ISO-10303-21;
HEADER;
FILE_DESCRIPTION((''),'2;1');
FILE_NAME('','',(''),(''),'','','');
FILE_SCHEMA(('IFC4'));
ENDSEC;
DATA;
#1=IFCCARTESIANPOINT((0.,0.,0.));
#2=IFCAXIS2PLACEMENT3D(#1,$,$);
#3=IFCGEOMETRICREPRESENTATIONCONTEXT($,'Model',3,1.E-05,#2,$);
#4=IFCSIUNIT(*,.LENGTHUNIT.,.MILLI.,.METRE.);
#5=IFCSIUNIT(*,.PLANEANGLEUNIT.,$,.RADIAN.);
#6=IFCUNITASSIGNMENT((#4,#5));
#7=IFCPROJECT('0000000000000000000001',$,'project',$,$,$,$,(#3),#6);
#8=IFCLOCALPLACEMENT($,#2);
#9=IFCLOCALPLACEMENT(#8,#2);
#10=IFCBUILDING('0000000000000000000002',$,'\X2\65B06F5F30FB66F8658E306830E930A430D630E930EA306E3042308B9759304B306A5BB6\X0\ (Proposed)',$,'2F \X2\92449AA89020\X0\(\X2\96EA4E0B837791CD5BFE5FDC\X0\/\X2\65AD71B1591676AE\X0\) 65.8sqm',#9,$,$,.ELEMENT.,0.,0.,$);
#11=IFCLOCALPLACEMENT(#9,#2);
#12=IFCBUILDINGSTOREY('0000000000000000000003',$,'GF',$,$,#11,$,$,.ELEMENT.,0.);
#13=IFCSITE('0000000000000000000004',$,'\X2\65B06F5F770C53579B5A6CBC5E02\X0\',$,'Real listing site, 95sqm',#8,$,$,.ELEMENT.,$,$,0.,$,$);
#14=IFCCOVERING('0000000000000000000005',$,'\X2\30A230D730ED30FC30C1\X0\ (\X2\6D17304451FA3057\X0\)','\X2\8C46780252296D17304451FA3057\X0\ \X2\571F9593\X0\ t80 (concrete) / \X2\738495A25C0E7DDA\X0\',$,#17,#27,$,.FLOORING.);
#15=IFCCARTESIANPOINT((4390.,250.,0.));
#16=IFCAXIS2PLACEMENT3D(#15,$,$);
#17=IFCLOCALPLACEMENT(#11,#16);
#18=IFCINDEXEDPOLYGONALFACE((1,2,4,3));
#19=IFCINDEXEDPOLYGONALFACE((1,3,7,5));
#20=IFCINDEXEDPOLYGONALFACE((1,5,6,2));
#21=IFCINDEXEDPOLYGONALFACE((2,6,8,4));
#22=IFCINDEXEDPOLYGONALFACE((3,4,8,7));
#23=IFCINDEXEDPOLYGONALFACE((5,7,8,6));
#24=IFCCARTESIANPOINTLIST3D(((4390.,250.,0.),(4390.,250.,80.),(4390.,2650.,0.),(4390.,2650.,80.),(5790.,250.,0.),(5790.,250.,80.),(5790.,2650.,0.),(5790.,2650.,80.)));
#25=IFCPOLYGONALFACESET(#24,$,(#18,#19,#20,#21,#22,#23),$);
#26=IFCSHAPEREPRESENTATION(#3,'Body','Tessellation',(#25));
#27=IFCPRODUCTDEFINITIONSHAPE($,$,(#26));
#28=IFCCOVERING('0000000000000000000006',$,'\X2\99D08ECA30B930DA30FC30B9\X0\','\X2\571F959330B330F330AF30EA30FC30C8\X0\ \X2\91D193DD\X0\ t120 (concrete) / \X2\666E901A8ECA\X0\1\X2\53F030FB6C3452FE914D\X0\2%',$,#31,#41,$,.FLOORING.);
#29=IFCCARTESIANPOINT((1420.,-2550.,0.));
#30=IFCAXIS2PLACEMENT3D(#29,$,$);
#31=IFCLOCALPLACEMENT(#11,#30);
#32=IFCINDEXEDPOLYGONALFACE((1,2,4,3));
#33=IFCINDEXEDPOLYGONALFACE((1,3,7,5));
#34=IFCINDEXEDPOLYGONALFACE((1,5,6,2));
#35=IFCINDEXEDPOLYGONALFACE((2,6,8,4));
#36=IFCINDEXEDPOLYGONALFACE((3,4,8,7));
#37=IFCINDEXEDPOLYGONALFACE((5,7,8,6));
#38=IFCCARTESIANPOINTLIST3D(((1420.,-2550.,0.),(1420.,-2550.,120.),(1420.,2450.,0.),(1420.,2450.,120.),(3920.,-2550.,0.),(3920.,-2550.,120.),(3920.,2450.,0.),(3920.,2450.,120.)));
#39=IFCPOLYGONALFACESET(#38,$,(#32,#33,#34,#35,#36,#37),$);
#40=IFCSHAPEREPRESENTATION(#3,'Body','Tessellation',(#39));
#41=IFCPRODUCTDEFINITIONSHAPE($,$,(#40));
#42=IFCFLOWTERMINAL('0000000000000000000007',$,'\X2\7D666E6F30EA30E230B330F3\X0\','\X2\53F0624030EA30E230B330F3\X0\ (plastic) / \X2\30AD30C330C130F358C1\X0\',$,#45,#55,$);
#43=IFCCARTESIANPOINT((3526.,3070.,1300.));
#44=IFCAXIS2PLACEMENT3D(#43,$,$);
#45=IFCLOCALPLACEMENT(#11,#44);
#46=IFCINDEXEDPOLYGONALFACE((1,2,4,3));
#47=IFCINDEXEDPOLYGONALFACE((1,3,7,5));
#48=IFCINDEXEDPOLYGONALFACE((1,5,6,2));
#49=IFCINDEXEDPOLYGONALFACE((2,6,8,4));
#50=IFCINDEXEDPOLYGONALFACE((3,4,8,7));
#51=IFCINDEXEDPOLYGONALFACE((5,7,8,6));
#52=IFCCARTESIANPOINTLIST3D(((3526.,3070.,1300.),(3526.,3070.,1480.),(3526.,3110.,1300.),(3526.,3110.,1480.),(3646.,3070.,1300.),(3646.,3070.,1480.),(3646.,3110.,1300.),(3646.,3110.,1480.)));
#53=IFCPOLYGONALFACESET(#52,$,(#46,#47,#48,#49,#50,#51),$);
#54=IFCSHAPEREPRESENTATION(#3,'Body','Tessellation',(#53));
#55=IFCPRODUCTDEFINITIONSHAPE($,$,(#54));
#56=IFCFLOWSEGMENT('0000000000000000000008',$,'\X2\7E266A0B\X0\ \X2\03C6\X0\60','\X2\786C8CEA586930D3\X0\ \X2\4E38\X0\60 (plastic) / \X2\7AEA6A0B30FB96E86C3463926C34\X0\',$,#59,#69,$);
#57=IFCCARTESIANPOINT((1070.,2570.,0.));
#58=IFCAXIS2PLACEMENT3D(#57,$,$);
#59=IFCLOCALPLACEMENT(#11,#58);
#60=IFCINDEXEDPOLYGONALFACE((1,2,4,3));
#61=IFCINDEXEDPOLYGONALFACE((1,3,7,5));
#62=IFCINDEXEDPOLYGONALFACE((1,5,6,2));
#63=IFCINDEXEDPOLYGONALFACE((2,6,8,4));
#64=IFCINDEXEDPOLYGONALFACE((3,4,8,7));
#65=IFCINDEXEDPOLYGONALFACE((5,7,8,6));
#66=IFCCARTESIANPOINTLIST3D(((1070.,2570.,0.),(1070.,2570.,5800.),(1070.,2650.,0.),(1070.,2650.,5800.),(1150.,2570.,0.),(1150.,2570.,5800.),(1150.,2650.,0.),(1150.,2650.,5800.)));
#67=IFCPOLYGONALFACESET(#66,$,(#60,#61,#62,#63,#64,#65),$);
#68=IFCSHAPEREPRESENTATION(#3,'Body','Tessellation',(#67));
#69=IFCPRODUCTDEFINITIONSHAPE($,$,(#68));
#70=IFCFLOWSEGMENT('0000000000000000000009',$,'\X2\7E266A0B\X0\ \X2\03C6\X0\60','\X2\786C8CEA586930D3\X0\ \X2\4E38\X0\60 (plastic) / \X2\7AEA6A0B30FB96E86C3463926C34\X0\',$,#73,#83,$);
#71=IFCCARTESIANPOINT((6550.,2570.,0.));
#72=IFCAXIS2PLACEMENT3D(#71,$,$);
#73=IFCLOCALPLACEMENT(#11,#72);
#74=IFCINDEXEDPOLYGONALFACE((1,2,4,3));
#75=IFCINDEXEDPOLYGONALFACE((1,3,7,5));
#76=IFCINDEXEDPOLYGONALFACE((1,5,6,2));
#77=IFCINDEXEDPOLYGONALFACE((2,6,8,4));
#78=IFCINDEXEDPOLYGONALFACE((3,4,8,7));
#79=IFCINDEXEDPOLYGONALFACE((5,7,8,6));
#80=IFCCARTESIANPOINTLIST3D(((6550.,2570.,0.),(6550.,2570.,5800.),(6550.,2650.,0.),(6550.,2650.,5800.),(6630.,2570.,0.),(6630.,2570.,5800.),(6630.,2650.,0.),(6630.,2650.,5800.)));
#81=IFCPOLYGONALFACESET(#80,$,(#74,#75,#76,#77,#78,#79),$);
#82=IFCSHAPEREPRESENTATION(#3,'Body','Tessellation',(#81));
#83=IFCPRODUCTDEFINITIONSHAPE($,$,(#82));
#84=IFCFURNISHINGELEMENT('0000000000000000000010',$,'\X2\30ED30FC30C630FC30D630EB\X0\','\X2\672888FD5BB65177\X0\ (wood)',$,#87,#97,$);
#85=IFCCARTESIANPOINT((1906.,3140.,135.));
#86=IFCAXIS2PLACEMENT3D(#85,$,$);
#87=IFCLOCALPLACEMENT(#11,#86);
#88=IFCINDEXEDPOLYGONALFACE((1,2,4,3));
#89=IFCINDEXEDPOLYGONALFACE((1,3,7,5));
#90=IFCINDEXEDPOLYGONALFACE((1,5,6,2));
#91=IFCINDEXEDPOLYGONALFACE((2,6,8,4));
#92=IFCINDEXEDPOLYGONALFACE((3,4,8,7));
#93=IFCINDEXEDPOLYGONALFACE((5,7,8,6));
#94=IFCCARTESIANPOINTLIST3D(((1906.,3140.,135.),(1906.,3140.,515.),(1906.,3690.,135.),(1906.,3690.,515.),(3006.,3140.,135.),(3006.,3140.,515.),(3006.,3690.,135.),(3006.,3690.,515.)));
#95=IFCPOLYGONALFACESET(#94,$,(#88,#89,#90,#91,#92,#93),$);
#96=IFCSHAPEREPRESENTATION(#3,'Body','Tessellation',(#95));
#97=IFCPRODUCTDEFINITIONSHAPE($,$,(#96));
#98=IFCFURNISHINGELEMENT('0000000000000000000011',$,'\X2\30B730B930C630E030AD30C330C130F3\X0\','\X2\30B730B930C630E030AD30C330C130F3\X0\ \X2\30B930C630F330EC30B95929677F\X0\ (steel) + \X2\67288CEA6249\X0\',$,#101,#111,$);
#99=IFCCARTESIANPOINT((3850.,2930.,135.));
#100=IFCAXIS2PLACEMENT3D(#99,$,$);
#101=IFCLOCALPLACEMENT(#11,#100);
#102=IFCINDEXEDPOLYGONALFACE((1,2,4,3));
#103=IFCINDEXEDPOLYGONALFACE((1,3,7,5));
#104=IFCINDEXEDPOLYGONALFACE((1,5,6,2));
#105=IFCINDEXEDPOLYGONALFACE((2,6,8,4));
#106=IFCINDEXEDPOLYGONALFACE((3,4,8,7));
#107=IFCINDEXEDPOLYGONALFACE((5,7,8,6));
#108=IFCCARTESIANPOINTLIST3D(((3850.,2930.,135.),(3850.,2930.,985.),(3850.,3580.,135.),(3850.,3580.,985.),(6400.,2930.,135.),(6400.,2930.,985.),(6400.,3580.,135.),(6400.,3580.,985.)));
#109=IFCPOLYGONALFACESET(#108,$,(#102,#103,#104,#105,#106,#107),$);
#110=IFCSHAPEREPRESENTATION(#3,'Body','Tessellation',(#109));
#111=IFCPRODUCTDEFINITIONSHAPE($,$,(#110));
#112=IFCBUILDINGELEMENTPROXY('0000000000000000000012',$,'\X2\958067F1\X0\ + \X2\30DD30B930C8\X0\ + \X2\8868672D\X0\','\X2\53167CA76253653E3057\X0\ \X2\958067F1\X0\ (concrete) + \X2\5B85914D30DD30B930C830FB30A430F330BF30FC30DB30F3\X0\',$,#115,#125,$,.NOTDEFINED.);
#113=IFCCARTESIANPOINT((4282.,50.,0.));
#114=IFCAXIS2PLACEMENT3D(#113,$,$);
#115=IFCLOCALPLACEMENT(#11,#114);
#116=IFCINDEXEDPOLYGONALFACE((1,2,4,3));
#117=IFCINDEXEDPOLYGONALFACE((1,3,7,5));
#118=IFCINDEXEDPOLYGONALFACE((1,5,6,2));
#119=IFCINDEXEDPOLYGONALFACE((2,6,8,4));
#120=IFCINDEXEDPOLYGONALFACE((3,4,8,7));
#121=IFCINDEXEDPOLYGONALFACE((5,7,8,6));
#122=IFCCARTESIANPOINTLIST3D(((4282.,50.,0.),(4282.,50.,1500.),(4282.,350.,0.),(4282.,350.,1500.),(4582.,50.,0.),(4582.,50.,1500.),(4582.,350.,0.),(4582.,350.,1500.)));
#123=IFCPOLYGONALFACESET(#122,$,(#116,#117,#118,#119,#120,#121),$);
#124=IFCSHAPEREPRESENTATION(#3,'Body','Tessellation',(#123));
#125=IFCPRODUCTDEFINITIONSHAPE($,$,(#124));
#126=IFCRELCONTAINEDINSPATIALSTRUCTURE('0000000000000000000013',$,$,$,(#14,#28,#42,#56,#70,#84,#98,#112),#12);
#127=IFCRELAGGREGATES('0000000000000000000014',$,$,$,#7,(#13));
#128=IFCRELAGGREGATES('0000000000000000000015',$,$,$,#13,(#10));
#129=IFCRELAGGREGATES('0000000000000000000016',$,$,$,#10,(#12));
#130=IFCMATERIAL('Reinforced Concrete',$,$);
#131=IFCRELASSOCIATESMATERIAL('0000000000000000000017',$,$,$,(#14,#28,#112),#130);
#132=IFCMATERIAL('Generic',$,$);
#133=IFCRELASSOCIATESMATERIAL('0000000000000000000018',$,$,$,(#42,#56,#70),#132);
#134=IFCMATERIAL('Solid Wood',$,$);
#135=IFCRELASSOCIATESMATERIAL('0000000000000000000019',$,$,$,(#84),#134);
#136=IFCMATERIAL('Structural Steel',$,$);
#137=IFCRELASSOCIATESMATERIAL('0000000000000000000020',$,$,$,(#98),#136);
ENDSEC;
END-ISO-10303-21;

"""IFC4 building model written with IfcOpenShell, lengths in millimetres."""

from ifc_helpers import new_model, si_unit, frame, frame_2d, origin, place, context, project, spatial, rectangle, extrude, material, element, save


model = new_model("IFC4")

# Units and contexts
model_context = context("Model", 3, precision=1e-05, world=origin())
ifc_project = project(units=[si_unit("LENGTHUNIT", "METRE", prefix="MILLI"), si_unit("PLANEANGLEUNIT", "RADIAN")], contexts=[model_context])

# Site, building, storey
site_placement = place(None, origin())
site = spatial("IfcSite", under=ifc_project, at=site_placement, Name="新潟県南魚沼市", ObjectType="Real listing site, 95sqm", CompositionType="ELEMENT", RefElevation=0.0)
building_placement = place(site_placement, origin())
building = spatial("IfcBuilding", under=site, at=building_placement, Name="新潟・書斎とライブラリのある静かな家 (Proposed)", ObjectType="2F 鉄骨造(雪下荷重対応/断熱外皮) 65.8sqm", CompositionType="ELEMENT", ElevationOfRefHeight=0.0, ElevationOfTerrain=0.0)
storey_placement = place(building_placement, origin())
storey = spatial("IfcBuildingStorey", under=building, at=storey_placement, Name="GF", CompositionType="ELEMENT", Elevation=0.0)

# Shared definitions
ifc_material_1 = material(Name="Solid Wood")

# Shared definitions
ifc_material_2 = material(Name="Reinforced Concrete")

# Coverings
ifc_material_3 = material(Name="Generic")
covering_1_placement = place(storey_placement, frame((4390.0, 250.0, 0.0)))
element("IfcCovering", 1, at=covering_1_placement, inside=storey, material=ifc_material_2, Name="アプローチ (洗い出し)", Description="豆砂利洗い出し 土間 t80 (concrete) / 玄関導線", PredefinedType="FLOORING", context=model_context, shape_type="SweptSolid", body=[
    extrude(rectangle(XDim=1400.0, YDim=2400.0, at=frame_2d((700.0, 1200.0))), frame((4390.0, 250.0, 0.0)), (0.0, 0.0, 1.0), 80.0),
])
covering_2_placement = place(storey_placement, frame((1420.0, -2550.0, 0.0)))
element("IfcCovering", 2, at=covering_2_placement, inside=storey, material=ifc_material_2, Name="駐車スペース", Description="土間コンクリート 金鏝 t120 (concrete) / 普通車1台・水勾配2%", PredefinedType="FLOORING", context=model_context, shape_type="SweptSolid", body=[
    extrude(rectangle(XDim=2500.0, YDim=5000.0, at=frame_2d((1250.0, 2500.0))), frame((1420.0, -2550.0, 0.0)), (0.0, 0.0, 1.0), 120.0),
])

# Flow terminal
flow_terminal_placement = place(storey_placement, frame((3526.0, 3070.0, 1300.0)))
element("IfcFlowTerminal", 3, at=flow_terminal_placement, inside=storey, material=ifc_material_3, Name="給湯リモコン", Description="台所リモコン (plastic) / キッチン壁", context=model_context, shape_type="SweptSolid", body=[
    extrude(rectangle(XDim=120.0, YDim=40.0, at=frame_2d((60.0, 20.0))), frame((3526.0, 3070.0, 1300.0)), (0.0, 0.0, 1.0), 180.0),
])

# Flow segments
flow_segment_1_placement = place(storey_placement, frame((1070.0, 2570.0, 0.0)))
element("IfcFlowSegment", 4, at=flow_segment_1_placement, inside=storey, material=ifc_material_3, Name="縦樋 φ60", Description="硬質塩ビ 丸60 (plastic) / 竪樋・雨水排水", context=model_context, shape_type="SweptSolid", body=[
    extrude(rectangle(XDim=80.0, YDim=80.0, at=frame_2d((40.0, 40.0))), frame((1070.0, 2570.0, 0.0)), (0.0, 0.0, 1.0), 5800.0),
])
flow_segment_2_placement = place(storey_placement, frame((6550.0, 2570.0, 0.0)))
element("IfcFlowSegment", 5, at=flow_segment_2_placement, inside=storey, material=ifc_material_3, Name="縦樋 φ60", Description="硬質塩ビ 丸60 (plastic) / 竪樋・雨水排水", context=model_context, shape_type="SweptSolid", body=[
    extrude(rectangle(XDim=80.0, YDim=80.0, at=frame_2d((40.0, 40.0))), frame((6550.0, 2570.0, 0.0)), (0.0, 0.0, 1.0), 5800.0),
])

# Furnishing elements
furnishing_1_placement = place(storey_placement, frame((1906.0, 3140.0, 135.0)))
element("IfcFurnishingElement", 6, at=furnishing_1_placement, inside=storey, material=ifc_material_1, Name="ローテーブル", Description="木製家具 (wood)", context=model_context, shape_type="SweptSolid", body=[
    extrude(rectangle(XDim=1100.0, YDim=550.0, at=frame_2d((550.0, 275.0))), frame((1906.0, 3140.0, 135.0)), (0.0, 0.0, 1.0), 380.0),
])
ifc_material_4 = material(Name="Structural Steel")
furnishing_2_placement = place(storey_placement, frame((3850.0, 2930.0, 135.0)))
element("IfcFurnishingElement", 7, at=furnishing_2_placement, inside=storey, material=ifc_material_4, Name="システムキッチン", Description="システムキッチン ステンレス天板 (steel) + 木質扉", context=model_context, shape_type="SweptSolid", body=[
    extrude(rectangle(XDim=2550.0, YDim=650.0, at=frame_2d((1275.0, 325.0))), frame((3850.0, 2930.0, 135.0)), (0.0, 0.0, 1.0), 850.0),
])

# Building element proxy
proxy_placement = place(storey_placement, frame((4282.0, 50.0, 0.0)))
element("IfcBuildingElementProxy", 8, at=proxy_placement, inside=storey, material=ifc_material_2, Name="門柱 + ポスト + 表札", Description="化粧打放し 門柱 (concrete) + 宅配ポスト・インターホン", PredefinedType="NOTDEFINED", context=model_context, shape_type="SweptSolid", body=[
    extrude(rectangle(XDim=300.0, YDim=300.0, at=frame_2d((150.0, 150.0))), frame((4282.0, 50.0, 0.0)), (0.0, 0.0, 1.0), 1500.0),
])

save(model, "model.ifc")
